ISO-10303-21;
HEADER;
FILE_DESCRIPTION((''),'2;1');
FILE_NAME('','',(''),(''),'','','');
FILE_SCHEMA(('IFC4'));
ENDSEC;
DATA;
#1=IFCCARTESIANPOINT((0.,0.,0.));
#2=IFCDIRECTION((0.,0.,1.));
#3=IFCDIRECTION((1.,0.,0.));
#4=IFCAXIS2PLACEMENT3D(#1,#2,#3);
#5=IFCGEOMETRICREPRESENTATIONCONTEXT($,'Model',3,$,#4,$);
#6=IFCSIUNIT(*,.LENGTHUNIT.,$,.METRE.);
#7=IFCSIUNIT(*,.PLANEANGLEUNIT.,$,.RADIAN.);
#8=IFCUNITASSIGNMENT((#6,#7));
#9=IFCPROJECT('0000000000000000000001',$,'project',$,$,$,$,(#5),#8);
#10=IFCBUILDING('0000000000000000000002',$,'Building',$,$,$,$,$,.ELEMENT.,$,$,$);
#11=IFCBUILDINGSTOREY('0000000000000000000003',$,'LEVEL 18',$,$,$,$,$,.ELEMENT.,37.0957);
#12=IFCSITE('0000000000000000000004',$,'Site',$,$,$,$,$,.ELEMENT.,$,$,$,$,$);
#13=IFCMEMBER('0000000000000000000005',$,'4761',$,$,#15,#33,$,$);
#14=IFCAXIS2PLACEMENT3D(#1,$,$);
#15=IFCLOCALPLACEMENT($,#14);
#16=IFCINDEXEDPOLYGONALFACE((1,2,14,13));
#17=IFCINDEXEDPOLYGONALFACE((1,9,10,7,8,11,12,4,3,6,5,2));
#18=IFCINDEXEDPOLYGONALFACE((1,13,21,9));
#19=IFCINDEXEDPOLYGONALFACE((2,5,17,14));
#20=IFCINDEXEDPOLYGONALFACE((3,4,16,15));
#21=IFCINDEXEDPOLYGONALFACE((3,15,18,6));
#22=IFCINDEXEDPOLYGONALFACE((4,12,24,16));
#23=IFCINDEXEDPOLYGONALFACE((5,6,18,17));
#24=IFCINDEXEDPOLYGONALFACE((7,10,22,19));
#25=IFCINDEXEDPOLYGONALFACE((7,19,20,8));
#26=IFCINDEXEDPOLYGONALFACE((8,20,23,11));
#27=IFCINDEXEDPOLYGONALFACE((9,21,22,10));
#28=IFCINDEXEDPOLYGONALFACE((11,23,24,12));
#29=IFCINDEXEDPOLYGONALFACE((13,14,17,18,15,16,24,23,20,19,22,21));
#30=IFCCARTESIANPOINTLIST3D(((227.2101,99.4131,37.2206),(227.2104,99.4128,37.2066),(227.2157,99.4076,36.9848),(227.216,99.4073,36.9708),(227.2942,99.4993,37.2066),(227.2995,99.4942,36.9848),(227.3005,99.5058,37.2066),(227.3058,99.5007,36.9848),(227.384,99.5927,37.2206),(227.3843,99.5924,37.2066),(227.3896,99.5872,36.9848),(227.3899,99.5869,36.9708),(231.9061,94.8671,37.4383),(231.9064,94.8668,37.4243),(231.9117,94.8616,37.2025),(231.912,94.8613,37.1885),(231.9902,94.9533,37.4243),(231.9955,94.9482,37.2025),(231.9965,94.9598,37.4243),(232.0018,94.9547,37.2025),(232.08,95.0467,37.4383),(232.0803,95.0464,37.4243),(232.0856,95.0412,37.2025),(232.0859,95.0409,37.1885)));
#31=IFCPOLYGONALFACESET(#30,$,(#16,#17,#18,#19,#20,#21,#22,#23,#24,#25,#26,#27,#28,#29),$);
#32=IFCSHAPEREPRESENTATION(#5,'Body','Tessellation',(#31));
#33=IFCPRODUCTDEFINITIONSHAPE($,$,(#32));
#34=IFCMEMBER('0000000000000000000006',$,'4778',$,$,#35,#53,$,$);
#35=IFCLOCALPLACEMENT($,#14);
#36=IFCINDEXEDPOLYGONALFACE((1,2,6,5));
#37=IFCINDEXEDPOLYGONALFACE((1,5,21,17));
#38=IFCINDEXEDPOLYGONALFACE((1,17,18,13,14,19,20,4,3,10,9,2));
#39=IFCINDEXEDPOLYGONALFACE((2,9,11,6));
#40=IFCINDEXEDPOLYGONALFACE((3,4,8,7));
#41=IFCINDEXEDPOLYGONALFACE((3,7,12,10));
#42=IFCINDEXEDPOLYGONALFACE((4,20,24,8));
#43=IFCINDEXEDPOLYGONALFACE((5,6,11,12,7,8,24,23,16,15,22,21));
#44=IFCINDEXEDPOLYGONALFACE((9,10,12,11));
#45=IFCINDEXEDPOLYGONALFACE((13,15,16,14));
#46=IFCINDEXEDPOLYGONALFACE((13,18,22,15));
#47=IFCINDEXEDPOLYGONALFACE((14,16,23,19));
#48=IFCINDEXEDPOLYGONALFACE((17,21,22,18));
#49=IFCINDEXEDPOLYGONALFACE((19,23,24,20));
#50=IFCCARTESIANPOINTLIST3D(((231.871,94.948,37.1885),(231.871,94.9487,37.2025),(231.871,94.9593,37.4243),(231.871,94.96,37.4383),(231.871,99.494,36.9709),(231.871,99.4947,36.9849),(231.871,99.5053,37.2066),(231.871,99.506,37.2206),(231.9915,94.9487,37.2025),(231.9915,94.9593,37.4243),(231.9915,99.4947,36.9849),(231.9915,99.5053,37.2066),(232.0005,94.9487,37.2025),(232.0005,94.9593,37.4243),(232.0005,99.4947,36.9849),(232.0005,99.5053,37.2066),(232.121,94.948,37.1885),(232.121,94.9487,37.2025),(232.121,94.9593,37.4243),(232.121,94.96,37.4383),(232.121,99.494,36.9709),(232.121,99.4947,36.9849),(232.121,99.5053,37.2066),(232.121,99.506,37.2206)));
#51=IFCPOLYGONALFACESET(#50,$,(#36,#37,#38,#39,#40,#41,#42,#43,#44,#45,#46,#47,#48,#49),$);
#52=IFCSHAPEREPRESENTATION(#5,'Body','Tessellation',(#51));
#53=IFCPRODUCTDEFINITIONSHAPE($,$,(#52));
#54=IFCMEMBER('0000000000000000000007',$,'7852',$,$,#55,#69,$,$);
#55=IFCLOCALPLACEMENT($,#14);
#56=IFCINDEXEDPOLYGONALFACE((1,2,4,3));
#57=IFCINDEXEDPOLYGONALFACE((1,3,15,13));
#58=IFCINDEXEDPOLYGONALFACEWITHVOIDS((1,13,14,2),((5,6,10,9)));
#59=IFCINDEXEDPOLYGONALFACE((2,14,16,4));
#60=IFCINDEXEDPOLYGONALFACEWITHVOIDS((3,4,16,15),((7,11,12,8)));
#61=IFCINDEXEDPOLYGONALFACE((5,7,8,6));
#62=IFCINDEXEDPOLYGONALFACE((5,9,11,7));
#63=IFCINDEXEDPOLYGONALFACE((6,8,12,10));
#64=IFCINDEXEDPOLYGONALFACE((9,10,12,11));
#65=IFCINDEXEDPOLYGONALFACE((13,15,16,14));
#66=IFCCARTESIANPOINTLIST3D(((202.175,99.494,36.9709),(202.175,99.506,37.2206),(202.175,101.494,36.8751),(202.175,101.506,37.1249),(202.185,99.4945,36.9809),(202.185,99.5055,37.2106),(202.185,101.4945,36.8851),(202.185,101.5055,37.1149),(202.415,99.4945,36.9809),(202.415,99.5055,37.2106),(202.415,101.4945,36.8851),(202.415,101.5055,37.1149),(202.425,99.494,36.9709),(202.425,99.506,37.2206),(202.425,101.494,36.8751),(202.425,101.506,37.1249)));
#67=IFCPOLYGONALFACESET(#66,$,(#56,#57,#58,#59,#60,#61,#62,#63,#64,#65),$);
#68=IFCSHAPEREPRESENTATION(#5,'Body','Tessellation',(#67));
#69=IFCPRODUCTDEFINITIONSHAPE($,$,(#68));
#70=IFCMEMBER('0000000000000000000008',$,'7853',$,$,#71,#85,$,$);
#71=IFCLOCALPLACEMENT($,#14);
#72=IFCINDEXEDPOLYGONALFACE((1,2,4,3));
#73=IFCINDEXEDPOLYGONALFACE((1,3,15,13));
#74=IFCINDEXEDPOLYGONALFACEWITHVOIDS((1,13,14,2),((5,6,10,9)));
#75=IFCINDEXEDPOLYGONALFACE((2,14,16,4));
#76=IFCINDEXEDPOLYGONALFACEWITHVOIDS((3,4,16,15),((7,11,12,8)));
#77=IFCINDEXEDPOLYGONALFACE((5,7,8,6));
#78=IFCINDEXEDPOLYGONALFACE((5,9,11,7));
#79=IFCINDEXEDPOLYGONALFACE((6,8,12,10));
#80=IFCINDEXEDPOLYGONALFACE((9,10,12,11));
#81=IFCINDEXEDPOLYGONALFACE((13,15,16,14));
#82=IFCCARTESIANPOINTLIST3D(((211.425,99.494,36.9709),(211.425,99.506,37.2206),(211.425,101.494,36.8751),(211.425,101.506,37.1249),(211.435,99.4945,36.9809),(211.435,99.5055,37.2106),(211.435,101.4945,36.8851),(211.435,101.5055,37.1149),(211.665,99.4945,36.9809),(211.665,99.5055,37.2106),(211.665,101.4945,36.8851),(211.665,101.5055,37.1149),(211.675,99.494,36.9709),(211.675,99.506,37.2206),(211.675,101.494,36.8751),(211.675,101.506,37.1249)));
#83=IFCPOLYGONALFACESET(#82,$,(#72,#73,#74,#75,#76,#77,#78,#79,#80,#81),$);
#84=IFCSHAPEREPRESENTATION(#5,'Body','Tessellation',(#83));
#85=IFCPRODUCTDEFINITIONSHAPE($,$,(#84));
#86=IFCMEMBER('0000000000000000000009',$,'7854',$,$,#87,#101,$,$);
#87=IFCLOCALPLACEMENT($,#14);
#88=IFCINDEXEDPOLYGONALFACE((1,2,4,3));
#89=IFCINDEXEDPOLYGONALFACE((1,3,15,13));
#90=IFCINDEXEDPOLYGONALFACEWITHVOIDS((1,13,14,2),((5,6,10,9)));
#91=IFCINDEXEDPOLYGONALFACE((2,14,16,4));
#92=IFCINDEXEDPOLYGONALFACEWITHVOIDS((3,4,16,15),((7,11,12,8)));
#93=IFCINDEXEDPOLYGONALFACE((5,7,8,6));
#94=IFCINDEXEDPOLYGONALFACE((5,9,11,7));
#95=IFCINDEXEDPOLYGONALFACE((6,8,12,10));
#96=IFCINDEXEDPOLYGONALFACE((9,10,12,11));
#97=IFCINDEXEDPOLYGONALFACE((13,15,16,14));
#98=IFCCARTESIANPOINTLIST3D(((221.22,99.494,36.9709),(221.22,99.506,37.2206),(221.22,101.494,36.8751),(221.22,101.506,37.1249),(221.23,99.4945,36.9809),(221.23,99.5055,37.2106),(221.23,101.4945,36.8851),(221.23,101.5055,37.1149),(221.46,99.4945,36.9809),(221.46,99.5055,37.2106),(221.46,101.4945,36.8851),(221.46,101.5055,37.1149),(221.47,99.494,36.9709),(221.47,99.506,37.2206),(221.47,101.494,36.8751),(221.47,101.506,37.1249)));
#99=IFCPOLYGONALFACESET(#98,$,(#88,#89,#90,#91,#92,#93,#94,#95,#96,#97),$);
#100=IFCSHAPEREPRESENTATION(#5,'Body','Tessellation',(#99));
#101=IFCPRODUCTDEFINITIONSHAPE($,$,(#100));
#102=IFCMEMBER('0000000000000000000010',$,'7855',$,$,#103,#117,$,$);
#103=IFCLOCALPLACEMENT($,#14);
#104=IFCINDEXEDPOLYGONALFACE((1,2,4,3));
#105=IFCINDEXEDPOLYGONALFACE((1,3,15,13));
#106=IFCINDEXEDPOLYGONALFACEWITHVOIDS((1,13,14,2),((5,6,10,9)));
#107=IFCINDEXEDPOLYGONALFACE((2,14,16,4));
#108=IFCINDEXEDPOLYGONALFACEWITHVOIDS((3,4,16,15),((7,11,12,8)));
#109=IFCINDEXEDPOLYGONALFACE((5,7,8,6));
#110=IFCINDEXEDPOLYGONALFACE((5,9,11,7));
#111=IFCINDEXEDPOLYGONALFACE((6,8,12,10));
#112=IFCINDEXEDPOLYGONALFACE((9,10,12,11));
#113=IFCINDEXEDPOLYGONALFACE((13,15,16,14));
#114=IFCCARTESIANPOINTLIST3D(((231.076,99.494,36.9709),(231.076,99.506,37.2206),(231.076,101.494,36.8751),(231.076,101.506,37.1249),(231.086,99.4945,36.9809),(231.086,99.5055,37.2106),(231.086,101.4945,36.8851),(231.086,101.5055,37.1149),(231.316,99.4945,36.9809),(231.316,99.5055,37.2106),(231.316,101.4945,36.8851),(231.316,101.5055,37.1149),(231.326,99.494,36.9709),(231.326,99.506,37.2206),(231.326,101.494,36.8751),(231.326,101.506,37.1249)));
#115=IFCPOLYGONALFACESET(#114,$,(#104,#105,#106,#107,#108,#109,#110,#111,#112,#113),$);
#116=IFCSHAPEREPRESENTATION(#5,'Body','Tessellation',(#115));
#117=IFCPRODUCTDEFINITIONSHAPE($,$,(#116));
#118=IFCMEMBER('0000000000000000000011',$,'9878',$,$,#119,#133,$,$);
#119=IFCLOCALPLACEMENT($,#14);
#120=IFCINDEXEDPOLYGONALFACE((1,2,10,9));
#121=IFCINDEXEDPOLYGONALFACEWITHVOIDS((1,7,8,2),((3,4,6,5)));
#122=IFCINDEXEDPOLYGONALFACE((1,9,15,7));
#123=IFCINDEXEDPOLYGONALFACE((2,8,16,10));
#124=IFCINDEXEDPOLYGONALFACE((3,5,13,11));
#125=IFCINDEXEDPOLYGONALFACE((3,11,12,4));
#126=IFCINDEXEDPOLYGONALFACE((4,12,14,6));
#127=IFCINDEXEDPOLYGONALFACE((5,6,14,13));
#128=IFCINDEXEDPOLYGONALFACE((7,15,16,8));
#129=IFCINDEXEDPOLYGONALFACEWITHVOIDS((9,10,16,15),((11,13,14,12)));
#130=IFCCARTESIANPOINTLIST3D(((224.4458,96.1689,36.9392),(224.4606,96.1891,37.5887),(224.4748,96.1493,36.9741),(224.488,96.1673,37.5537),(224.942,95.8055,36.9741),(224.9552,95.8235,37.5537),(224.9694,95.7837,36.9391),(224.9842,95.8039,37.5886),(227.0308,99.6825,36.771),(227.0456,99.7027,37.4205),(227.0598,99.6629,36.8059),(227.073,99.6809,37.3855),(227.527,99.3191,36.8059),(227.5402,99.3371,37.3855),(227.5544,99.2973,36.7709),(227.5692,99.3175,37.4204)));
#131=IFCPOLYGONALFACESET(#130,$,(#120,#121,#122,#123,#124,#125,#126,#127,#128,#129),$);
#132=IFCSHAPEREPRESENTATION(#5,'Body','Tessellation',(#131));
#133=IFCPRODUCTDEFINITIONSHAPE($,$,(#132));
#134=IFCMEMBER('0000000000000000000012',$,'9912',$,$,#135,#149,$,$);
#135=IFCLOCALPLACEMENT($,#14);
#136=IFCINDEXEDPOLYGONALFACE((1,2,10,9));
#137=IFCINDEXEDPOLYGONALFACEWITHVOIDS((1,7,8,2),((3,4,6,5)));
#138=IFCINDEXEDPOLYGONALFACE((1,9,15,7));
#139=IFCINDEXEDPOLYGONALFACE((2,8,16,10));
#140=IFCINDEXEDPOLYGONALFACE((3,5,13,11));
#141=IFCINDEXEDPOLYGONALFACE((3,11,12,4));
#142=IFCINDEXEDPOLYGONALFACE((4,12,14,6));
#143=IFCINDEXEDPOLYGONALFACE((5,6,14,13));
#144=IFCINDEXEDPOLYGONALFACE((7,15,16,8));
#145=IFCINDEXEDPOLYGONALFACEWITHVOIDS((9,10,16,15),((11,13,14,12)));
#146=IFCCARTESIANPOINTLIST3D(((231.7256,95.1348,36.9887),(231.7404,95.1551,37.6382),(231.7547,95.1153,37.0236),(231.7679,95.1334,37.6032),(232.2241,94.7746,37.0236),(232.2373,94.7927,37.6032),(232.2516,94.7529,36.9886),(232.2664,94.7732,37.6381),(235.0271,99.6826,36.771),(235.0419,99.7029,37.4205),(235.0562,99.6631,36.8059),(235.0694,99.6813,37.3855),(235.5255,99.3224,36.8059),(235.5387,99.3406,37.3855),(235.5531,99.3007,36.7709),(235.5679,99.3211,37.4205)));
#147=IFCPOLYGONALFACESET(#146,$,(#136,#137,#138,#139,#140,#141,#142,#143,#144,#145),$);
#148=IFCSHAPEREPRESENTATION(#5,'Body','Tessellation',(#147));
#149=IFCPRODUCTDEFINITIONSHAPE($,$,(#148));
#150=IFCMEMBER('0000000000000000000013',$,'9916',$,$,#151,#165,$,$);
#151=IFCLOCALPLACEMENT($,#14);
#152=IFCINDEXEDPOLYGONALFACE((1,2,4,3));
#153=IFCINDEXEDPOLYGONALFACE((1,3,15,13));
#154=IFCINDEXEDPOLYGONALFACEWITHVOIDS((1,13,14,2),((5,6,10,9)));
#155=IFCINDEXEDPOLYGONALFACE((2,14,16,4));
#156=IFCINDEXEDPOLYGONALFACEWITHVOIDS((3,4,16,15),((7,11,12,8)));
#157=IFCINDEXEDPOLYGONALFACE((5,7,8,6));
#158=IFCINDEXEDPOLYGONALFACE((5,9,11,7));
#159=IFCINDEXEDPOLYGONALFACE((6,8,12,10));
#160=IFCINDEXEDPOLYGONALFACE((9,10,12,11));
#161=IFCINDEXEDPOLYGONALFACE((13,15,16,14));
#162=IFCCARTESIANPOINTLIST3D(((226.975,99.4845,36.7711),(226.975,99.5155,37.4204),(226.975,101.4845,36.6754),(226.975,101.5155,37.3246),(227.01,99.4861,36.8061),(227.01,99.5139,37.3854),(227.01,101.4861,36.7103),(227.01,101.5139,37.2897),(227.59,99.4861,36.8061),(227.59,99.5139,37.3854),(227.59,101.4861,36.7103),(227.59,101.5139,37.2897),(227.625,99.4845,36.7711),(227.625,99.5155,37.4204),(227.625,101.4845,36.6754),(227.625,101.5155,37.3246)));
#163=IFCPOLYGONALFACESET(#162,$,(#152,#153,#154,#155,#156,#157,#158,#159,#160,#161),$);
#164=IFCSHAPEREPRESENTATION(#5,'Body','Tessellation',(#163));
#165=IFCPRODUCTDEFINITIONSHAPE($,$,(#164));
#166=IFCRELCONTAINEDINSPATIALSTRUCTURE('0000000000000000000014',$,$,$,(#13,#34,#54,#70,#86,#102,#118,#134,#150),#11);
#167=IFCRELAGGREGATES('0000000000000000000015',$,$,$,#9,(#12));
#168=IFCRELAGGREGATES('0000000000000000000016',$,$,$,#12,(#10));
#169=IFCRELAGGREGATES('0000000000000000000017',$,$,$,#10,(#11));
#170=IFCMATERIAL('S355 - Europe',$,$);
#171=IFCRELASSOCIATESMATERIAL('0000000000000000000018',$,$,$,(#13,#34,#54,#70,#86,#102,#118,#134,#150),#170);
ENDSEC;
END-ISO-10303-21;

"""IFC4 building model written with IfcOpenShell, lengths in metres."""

from ifc_helpers import new_model, si_unit, frame, origin_with_axes, origin_2d_with_axis, place, context, project, spatial, hollow_rectangle, i_section, extrude, material, material_profile, profile_set, profile_usage, element, save


model = new_model("IFC4")

# Units and contexts
model_context = context("Model", 3, world=origin_with_axes())
ifc_project = project(units=[si_unit("LENGTHUNIT", "METRE"), si_unit("PLANEANGLEUNIT", "RADIAN")], contexts=[model_context])

# Site, building, storey
site = spatial("IfcSite", under=ifc_project, Name="Site", CompositionType="ELEMENT")
building = spatial("IfcBuilding", under=site, Name="Building", CompositionType="ELEMENT")
storey = spatial("IfcBuildingStorey", under=building, Name="LEVEL 18", CompositionType="ELEMENT", Elevation=37.0957)

# Shared definitions
ifc_material = material(Name="S355 - Europe")

# Members
ifc_material_profile_1 = material_profile(ifc_material, i_section(OverallWidth=0.25, OverallDepth=0.25, WebThickness=0.009, FlangeThickness=0.014, at=origin_2d_with_axis()))
ifc_profile_set_1 = profile_set([ifc_material_profile_1])
ifc_profile_usage_1 = profile_usage(ifc_profile_set_1, cardinal=10)
member_1_placement = place(None, frame((227.3, 99.5, 37.0957), z_axis=(0.71809, -0.695153, 0.03329), x_axis=(0.69559, 0.718439, 0.0)))
element("IfcMember", 1, at=member_1_placement, inside=storey, material=ifc_profile_usage_1, Name="4761", context=model_context, shape_type="SweptSolid", body=[
    extrude(i_section(OverallWidth=0.25, OverallDepth=0.25, WebThickness=0.009, FlangeThickness=0.014, at=origin_2d_with_axis()), origin_with_axes(), (0.0, 0.0, 1.0), 6.5396),
])
ifc_material_profile_2 = material_profile(ifc_material, i_section(OverallWidth=0.25, OverallDepth=0.25, WebThickness=0.009, FlangeThickness=0.014, at=origin_2d_with_axis()))
ifc_profile_set_2 = profile_set([ifc_material_profile_2])
ifc_profile_usage_2 = profile_usage(ifc_profile_set_2, cardinal=10)
member_2_placement = place(None, frame((231.996, 94.954, 37.3134), z_axis=(0.0, 0.998856, -0.047828), x_axis=(-1.0, 0.0, 0.0)))
element("IfcMember", 2, at=member_2_placement, inside=storey, material=ifc_profile_usage_2, Name="4778", context=model_context, shape_type="SweptSolid", body=[
    extrude(i_section(OverallWidth=0.25, OverallDepth=0.25, WebThickness=0.009, FlangeThickness=0.014, at=origin_2d_with_axis()), origin_with_axes(), (0.0, 0.0, 1.0), 4.5512),
])
ifc_material_profile_3 = material_profile(ifc_material, hollow_rectangle(XDim=0.25, YDim=0.25, WallThickness=0.01, at=origin_2d_with_axis()))
ifc_profile_set_3 = profile_set([ifc_material_profile_3])
ifc_profile_usage_3 = profile_usage(ifc_profile_set_3, cardinal=10)
member_3_placement = place(None, frame((202.3, 101.5, 37.0), z_axis=(0.0, -0.998856, 0.047828), x_axis=(1.0, 0.0, 0.0)))
element("IfcMember", 3, at=member_3_placement, inside=storey, material=ifc_profile_usage_3, Name="7852", context=model_context, shape_type="SweptSolid", body=[
    extrude(hollow_rectangle(XDim=0.25, YDim=0.25, WallThickness=0.01, at=origin_2d_with_axis()), origin_with_axes(), (0.0, 0.0, 1.0), 2.0023),
])
ifc_material_profile_4 = material_profile(ifc_material, hollow_rectangle(XDim=0.25, YDim=0.25, WallThickness=0.01, at=origin_2d_with_axis()))
ifc_profile_set_4 = profile_set([ifc_material_profile_4])
ifc_profile_usage_4 = profile_usage(ifc_profile_set_4, cardinal=10)
member_4_placement = place(None, frame((211.55, 101.5, 37.0), z_axis=(0.0, -0.998856, 0.047828), x_axis=(1.0, 0.0, 0.0)))
element("IfcMember", 4, at=member_4_placement, inside=storey, material=ifc_profile_usage_4, Name="7853", context=model_context, shape_type="SweptSolid", body=[
    extrude(hollow_rectangle(XDim=0.25, YDim=0.25, WallThickness=0.01, at=origin_2d_with_axis()), origin_with_axes(), (0.0, 0.0, 1.0), 2.0023),
])
ifc_material_profile_5 = material_profile(ifc_material, hollow_rectangle(XDim=0.25, YDim=0.25, WallThickness=0.01, at=origin_2d_with_axis()))
ifc_profile_set_5 = profile_set([ifc_material_profile_5])
ifc_profile_usage_5 = profile_usage(ifc_profile_set_5, cardinal=10)
member_5_placement = place(None, frame((221.345, 101.5, 37.0), z_axis=(0.0, -0.998856, 0.047828), x_axis=(1.0, 0.0, 0.0)))
element("IfcMember", 5, at=member_5_placement, inside=storey, material=ifc_profile_usage_5, Name="7854", context=model_context, shape_type="SweptSolid", body=[
    extrude(hollow_rectangle(XDim=0.25, YDim=0.25, WallThickness=0.01, at=origin_2d_with_axis()), origin_with_axes(), (0.0, 0.0, 1.0), 2.0023),
])
ifc_material_profile_6 = material_profile(ifc_material, hollow_rectangle(XDim=0.25, YDim=0.25, WallThickness=0.01, at=origin_2d_with_axis()))
ifc_profile_set_6 = profile_set([ifc_material_profile_6])
ifc_profile_usage_6 = profile_usage(ifc_profile_set_6, cardinal=10)
member_6_placement = place(None, frame((231.201, 101.5, 37.0), z_axis=(0.0, -0.998856, 0.047828), x_axis=(1.0, 0.0, 0.0)))
element("IfcMember", 6, at=member_6_placement, inside=storey, material=ifc_profile_usage_6, Name="7855", context=model_context, shape_type="SweptSolid", body=[
    extrude(hollow_rectangle(XDim=0.25, YDim=0.25, WallThickness=0.01, at=origin_2d_with_axis()), origin_with_axes(), (0.0, 0.0, 1.0), 2.0023),
])
ifc_material_profile_7 = material_profile(ifc_material, hollow_rectangle(XDim=0.65, YDim=0.65, WallThickness=0.035, at=origin_2d_with_axis()))
ifc_profile_set_7 = profile_set([ifc_material_profile_7])
ifc_profile_usage_7 = profile_usage(ifc_profile_set_7, cardinal=10)
member_7_placement = place(None, frame((227.3, 99.5, 37.0957), z_axis=(-0.592169, -0.804892, 0.038531), x_axis=(0.805056, -0.593199, 0.0)))
element("IfcMember", 7, at=member_7_placement, inside=storey, material=ifc_profile_usage_7, Name="9878", context=model_context, shape_type="SweptSolid", body=[
    extrude(hollow_rectangle(XDim=0.65, YDim=0.65, WallThickness=0.035, at=origin_2d_with_axis()), origin_with_axes(), (0.0, 0.0, 1.0), 4.3653),
])
ifc_material_profile_8 = material_profile(ifc_material, hollow_rectangle(XDim=0.65, YDim=0.65, WallThickness=0.035, at=origin_2d_with_axis()))
ifc_profile_set_8 = profile_set([ifc_material_profile_8])
ifc_profile_usage_8 = profile_usage(ifc_profile_set_8, cardinal=10)
member_8_placement = place(None, frame((231.996, 94.954, 37.3134), z_axis=(0.587027, 0.808642, -0.038707), x_axis=(-0.808921, 0.587918, 0.0)))
element("IfcMember", 8, at=member_8_placement, inside=storey, material=ifc_profile_usage_8, Name="9912", context=model_context, shape_type="SweptSolid", body=[
    extrude(hollow_rectangle(XDim=0.65, YDim=0.65, WallThickness=0.035, at=origin_2d_with_axis()), origin_with_axes(), (0.0, 0.0, 1.0), 5.624),
])
ifc_material_profile_9 = material_profile(ifc_material, hollow_rectangle(XDim=0.65, YDim=0.65, WallThickness=0.035, at=origin_2d_with_axis()))
ifc_profile_set_9 = profile_set([ifc_material_profile_9])
ifc_profile_usage_9 = profile_usage(ifc_profile_set_9, cardinal=10)
member_9_placement = place(None, frame((227.3, 101.5, 37.0), z_axis=(0.0, -0.998856, 0.047828), x_axis=(1.0, 0.0, 0.0)))
element("IfcMember", 9, at=member_9_placement, inside=storey, material=ifc_profile_usage_9, Name="9916", context=model_context, shape_type="SweptSolid", body=[
    extrude(hollow_rectangle(XDim=0.65, YDim=0.65, WallThickness=0.035, at=origin_2d_with_axis()), origin_with_axes(), (0.0, 0.0, 1.0), 2.0023),
])

save(model, "model.ifc")
